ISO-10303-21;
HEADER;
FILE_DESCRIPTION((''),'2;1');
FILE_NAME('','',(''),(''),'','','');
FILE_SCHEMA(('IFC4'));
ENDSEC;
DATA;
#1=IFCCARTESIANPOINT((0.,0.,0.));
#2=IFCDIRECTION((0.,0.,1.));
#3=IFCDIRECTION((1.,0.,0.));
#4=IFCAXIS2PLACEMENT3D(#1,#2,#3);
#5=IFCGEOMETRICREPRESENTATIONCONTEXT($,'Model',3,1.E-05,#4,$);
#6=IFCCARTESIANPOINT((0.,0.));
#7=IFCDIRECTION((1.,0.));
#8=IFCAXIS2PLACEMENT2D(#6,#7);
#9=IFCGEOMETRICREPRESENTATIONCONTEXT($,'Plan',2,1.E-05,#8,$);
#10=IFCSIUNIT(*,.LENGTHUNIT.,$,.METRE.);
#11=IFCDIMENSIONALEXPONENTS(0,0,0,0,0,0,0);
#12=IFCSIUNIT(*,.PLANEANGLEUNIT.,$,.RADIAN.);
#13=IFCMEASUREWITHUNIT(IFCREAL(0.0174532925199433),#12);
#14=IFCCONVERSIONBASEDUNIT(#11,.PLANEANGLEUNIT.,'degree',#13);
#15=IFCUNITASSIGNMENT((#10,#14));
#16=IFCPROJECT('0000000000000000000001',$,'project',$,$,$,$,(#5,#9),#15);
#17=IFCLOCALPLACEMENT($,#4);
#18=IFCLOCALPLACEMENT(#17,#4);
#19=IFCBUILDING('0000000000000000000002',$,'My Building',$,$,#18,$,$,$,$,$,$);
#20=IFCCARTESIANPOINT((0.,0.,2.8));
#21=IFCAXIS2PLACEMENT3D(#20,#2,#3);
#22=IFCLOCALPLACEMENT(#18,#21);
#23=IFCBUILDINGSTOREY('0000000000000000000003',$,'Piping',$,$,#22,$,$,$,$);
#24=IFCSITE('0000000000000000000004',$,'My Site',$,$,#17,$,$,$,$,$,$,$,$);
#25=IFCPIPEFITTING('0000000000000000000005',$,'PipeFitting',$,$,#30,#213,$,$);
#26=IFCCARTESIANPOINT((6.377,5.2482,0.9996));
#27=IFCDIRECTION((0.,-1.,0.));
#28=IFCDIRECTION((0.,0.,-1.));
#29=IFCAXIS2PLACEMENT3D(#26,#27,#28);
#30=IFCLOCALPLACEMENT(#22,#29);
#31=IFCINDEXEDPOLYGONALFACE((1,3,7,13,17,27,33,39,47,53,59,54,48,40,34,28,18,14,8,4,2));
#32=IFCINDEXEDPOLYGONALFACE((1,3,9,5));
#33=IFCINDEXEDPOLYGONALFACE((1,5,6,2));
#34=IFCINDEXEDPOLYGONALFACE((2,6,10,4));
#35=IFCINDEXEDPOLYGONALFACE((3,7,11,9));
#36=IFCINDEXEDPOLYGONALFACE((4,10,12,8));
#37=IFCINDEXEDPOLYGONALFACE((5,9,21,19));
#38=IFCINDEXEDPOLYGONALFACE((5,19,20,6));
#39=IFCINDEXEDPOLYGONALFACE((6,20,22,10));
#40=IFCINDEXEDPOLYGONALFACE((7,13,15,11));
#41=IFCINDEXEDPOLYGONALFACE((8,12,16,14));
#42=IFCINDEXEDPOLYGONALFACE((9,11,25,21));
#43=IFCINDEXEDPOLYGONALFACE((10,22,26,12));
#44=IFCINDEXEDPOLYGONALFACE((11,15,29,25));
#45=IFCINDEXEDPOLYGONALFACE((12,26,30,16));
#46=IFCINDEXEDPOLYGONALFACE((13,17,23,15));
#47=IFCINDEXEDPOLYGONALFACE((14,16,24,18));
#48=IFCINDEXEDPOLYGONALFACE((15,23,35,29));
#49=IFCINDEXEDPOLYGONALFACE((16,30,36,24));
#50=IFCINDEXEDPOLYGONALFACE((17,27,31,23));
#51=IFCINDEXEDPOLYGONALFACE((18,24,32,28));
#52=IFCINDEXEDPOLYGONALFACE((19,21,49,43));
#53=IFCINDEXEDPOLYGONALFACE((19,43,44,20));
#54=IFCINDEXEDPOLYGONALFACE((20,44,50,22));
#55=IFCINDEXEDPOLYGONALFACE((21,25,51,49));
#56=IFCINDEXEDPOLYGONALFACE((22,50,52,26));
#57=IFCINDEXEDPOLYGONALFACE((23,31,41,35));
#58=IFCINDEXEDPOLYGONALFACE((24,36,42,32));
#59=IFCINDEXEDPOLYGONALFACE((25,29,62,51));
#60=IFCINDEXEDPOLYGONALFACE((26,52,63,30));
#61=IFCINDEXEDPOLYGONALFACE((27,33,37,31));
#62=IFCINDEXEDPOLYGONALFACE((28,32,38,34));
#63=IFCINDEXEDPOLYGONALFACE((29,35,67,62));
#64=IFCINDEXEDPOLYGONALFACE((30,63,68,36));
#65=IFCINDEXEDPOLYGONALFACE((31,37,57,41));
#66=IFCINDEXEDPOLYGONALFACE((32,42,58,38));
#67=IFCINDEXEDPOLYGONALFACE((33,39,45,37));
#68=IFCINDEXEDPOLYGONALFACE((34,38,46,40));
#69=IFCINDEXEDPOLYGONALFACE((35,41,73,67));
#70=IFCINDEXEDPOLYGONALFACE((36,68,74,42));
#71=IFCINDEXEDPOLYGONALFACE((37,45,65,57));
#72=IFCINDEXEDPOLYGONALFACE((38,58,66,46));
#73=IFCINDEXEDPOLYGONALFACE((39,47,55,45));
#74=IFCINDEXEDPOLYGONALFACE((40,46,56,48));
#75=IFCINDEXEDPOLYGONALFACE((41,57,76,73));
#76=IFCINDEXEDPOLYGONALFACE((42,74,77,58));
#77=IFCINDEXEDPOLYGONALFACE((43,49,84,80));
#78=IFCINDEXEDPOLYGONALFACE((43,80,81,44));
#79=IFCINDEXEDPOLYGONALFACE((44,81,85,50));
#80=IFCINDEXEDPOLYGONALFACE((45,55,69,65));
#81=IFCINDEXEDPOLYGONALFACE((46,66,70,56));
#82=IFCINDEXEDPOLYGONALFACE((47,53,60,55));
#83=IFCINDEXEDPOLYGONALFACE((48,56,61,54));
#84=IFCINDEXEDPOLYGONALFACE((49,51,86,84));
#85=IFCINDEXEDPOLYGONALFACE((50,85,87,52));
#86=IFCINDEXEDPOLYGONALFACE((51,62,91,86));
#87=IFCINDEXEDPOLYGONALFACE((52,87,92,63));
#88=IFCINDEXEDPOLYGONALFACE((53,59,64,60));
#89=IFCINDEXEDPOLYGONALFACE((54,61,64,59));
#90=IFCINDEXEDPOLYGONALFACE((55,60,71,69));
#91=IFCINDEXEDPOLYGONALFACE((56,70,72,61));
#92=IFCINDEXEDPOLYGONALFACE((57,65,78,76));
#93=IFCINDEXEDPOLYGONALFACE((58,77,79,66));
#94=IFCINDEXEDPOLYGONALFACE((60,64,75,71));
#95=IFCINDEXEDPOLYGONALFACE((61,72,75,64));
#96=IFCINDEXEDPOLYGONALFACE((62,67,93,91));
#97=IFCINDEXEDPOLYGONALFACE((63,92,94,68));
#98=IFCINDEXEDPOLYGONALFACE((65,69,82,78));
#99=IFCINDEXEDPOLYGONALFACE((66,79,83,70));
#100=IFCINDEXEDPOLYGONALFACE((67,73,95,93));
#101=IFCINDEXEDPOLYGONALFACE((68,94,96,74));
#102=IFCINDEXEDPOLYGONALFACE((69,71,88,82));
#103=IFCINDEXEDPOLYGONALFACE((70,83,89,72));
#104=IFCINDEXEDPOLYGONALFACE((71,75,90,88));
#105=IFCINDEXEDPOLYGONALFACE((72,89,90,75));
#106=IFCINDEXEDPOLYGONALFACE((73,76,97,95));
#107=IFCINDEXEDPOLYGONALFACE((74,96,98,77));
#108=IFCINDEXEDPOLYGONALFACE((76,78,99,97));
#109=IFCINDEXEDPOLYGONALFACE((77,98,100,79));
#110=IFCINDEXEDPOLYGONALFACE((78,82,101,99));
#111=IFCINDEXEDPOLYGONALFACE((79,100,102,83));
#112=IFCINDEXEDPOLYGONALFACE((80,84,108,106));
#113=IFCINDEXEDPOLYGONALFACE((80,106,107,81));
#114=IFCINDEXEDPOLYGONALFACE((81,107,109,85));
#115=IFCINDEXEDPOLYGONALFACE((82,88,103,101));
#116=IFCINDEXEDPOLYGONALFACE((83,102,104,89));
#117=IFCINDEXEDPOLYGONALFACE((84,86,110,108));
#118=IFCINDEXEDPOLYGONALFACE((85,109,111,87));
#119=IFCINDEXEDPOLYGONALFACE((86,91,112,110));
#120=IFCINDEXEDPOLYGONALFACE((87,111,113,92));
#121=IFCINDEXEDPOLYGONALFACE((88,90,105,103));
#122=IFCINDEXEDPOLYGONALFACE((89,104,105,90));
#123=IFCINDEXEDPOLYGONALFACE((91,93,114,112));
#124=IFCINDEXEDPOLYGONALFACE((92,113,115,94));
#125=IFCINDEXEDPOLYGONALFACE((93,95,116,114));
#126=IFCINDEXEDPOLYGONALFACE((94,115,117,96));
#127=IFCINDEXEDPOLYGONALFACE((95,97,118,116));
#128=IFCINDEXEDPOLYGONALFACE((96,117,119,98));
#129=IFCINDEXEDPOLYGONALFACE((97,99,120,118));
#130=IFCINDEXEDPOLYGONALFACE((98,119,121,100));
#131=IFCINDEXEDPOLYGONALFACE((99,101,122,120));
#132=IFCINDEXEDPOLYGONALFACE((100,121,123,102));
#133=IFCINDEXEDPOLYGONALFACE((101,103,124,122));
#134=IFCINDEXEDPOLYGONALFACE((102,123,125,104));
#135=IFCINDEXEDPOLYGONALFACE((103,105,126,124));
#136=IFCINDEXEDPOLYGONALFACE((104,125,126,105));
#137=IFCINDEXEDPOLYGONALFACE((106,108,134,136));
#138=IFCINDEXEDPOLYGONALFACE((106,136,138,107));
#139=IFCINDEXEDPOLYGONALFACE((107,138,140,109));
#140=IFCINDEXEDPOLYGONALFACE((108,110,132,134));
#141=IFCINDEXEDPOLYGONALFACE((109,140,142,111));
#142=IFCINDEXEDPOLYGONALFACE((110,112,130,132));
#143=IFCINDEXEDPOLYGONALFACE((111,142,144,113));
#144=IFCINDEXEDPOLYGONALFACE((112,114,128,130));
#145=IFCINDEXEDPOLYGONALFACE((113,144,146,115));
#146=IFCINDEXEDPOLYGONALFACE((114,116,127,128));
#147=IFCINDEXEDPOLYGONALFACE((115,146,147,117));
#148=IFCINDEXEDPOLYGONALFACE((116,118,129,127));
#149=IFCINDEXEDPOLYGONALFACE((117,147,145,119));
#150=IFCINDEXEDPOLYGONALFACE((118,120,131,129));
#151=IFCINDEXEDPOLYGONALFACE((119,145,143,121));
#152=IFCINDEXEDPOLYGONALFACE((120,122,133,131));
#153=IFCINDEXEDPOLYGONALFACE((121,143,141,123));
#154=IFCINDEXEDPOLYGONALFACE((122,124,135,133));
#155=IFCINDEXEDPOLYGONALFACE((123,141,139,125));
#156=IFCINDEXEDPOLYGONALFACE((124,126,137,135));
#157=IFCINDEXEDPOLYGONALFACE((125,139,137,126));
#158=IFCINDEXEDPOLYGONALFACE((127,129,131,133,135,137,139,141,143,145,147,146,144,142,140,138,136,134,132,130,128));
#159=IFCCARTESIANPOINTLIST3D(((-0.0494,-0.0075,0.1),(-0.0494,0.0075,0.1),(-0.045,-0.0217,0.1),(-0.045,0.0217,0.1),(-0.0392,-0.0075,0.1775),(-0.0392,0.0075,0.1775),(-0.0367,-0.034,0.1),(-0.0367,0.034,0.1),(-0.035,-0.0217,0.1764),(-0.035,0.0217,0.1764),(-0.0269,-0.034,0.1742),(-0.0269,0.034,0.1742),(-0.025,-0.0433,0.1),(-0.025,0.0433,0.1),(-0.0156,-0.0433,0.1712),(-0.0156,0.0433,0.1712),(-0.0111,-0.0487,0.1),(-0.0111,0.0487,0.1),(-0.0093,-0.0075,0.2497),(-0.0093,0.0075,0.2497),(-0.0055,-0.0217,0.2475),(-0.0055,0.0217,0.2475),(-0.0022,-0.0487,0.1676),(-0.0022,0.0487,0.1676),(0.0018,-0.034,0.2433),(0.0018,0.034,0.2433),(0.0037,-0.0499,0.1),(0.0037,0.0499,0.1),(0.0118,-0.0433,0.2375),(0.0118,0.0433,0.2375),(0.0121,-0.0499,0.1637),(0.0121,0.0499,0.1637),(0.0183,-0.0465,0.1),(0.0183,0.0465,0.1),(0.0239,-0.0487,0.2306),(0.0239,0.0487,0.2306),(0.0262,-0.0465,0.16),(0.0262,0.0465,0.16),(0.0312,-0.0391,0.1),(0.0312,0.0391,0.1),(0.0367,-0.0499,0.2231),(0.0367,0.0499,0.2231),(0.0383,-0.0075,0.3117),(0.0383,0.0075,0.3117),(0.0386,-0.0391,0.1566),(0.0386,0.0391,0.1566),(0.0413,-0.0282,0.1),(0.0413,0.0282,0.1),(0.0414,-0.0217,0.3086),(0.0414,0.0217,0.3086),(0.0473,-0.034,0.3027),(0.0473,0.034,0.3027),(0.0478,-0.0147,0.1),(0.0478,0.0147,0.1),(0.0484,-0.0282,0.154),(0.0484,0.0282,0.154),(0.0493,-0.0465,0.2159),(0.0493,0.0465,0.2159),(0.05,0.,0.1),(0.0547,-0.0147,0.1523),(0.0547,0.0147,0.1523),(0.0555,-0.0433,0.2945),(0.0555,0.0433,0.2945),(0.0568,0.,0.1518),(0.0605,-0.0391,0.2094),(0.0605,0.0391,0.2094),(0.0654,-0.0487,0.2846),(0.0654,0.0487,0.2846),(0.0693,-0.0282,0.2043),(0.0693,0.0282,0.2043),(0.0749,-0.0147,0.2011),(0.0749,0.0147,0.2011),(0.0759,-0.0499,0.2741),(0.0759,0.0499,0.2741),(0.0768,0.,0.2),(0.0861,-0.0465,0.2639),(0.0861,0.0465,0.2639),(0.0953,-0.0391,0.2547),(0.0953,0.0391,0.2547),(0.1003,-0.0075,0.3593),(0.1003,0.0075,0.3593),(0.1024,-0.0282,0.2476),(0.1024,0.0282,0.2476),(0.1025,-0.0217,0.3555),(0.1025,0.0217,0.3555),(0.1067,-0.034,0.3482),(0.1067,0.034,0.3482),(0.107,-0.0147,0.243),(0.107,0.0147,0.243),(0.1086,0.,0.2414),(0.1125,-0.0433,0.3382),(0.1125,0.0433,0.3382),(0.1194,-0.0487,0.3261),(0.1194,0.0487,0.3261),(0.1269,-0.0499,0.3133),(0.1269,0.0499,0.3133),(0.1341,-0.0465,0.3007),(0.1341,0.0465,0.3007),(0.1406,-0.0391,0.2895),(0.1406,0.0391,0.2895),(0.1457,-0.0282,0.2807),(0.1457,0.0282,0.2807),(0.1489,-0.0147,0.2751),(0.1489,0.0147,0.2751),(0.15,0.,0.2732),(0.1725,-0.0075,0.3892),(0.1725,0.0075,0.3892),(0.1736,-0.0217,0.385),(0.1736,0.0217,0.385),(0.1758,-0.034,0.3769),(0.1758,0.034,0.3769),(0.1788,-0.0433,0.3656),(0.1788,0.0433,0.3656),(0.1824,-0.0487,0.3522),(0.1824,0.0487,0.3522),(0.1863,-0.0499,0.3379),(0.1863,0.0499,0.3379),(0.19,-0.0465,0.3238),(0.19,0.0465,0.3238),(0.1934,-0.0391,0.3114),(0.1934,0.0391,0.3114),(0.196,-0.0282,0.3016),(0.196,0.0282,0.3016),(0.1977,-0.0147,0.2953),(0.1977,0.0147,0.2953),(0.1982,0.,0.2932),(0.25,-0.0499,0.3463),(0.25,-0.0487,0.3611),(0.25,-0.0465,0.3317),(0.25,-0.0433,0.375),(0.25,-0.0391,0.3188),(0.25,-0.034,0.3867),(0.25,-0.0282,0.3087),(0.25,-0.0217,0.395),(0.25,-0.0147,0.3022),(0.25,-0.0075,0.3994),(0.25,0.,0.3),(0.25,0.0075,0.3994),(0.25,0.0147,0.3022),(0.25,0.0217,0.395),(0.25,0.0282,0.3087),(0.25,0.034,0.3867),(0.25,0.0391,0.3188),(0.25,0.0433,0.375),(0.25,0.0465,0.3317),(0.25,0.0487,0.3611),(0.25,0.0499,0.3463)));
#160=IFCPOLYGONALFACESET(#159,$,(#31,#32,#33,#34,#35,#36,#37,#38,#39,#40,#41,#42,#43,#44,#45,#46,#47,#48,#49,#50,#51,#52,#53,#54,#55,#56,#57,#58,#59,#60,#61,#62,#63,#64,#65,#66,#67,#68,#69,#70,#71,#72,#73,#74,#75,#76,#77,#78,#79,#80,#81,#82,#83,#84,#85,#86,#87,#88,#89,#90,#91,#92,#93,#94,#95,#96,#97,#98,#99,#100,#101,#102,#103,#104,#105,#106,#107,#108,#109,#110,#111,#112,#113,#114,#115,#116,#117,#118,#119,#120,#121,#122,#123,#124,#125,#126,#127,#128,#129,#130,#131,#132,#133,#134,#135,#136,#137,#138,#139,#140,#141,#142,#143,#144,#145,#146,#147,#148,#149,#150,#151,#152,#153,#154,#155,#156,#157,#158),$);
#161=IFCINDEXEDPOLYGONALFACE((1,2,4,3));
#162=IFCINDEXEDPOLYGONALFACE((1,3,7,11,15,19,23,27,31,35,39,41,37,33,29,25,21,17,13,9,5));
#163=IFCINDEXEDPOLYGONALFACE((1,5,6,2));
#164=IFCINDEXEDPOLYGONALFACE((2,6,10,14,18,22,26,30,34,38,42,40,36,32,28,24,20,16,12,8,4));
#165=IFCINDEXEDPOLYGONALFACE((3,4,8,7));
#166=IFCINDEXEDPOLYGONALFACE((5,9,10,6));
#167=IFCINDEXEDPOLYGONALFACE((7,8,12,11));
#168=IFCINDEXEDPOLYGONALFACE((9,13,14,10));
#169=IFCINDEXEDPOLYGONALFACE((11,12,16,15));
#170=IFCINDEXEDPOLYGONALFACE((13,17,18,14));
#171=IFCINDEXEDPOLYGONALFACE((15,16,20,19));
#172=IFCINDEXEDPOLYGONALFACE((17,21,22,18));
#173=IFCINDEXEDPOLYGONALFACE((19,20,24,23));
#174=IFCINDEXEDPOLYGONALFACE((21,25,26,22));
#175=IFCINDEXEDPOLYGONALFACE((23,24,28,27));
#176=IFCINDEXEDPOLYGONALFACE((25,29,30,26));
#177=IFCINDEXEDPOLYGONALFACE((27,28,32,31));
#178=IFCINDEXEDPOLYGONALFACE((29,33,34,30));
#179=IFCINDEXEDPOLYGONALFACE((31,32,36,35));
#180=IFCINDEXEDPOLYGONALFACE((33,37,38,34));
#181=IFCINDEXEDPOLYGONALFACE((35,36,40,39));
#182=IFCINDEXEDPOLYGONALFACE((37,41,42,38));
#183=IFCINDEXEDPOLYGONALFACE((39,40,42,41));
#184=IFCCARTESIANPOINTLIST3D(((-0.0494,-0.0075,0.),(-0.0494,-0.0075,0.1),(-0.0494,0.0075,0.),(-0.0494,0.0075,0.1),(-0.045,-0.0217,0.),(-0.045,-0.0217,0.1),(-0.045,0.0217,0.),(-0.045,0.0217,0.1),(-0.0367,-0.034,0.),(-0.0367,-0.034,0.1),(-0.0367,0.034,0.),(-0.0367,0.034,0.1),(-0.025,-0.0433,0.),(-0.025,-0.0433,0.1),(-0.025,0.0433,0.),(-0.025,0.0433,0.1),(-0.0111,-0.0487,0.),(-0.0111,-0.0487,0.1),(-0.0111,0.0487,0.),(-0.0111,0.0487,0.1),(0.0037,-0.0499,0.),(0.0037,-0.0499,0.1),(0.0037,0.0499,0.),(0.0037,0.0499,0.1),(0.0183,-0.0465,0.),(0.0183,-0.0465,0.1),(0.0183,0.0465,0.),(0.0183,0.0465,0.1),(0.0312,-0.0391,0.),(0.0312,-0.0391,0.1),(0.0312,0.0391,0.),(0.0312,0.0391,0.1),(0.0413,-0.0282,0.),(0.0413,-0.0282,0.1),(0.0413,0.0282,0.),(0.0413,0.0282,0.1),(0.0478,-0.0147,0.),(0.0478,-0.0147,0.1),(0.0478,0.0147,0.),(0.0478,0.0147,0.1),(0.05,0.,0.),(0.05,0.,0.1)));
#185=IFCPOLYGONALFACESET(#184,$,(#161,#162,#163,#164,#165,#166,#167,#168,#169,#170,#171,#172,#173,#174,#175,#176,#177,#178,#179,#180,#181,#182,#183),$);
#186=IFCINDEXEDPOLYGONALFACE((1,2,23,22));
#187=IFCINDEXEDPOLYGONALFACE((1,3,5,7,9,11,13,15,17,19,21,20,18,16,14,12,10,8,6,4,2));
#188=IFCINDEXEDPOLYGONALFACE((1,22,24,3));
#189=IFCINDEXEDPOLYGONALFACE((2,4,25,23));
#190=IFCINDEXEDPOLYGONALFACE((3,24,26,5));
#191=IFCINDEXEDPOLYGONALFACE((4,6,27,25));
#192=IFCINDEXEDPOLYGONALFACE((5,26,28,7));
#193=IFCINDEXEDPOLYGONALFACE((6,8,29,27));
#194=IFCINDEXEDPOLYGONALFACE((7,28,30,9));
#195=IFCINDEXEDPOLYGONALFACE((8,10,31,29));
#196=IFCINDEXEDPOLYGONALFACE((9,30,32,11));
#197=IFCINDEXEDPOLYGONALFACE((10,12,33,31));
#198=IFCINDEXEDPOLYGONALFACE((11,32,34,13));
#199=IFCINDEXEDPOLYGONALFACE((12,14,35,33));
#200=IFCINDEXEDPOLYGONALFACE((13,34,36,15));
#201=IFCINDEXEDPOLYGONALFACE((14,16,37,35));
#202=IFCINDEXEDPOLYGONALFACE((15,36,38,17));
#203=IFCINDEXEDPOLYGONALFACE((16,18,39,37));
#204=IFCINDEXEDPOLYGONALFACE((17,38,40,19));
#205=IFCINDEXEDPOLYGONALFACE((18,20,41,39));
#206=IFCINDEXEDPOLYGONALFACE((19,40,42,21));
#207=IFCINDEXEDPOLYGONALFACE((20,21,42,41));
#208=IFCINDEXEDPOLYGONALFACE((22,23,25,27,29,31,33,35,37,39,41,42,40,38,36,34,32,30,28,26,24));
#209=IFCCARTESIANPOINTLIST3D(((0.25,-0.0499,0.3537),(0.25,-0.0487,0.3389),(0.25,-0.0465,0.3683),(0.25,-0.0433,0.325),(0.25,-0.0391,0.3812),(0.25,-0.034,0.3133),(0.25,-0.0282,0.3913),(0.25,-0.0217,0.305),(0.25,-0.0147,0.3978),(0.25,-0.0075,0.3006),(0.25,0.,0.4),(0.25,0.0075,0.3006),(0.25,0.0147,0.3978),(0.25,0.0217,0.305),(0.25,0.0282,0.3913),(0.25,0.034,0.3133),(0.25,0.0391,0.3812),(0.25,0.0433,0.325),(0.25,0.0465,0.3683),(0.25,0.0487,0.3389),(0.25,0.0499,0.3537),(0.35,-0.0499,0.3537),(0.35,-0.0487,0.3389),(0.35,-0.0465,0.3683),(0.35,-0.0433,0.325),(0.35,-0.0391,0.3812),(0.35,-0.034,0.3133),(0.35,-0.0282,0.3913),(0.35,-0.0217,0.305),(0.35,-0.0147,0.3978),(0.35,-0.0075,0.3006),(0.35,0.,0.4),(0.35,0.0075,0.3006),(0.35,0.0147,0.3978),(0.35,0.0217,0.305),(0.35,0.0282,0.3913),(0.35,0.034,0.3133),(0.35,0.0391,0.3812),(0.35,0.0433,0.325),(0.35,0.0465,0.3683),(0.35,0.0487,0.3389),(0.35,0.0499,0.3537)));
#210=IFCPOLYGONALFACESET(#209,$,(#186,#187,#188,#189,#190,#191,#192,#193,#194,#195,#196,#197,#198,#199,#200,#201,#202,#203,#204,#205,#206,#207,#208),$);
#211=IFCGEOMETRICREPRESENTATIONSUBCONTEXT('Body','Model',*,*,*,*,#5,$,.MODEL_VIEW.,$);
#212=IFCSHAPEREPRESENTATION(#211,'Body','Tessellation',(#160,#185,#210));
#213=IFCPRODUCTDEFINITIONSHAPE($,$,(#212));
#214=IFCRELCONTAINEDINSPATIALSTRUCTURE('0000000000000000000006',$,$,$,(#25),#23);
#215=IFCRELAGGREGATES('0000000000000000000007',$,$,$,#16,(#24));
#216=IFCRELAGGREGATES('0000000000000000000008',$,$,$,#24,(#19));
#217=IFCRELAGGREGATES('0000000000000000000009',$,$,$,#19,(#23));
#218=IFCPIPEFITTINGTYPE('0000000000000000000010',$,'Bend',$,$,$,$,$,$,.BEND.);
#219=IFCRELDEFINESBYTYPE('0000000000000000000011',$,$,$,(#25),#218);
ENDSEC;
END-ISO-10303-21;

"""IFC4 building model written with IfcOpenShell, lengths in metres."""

from ifc_helpers import new_model, entity, si_unit, converted_unit, frame, origin_with_axes, origin_2d_with_axis, place, context, subcontext, project, spatial, circle, extrude, source, transform, mapped, type_object, type_shapes, element, save


model = new_model("IFC4")

# Units and contexts
model_context = context("Model", 3, precision=1e-05, world=origin_with_axes())
plan_context = context("Plan", 2, precision=1e-05, world=origin_2d_with_axis())
body_context = subcontext(model_context, "Body", "Model", "MODEL_VIEW")
ifc_project = project(units=[si_unit("LENGTHUNIT", "METRE"), converted_unit("PLANEANGLEUNIT", "degree", entity("IfcReal", 0.0174532925199433), si_unit("PLANEANGLEUNIT", "RADIAN"), dimensions=[0, 0, 0, 0, 0, 0, 0])], contexts=[model_context, plan_context])

# Site, building, storey
site_placement = place(None, origin_with_axes())
site = spatial("IfcSite", under=ifc_project, at=site_placement, Name="My Site")
building_placement = place(site_placement, origin_with_axes())
building = spatial("IfcBuilding", under=site, at=building_placement, Name="My Building")
storey_placement = place(building_placement, frame((0.0, 0.0, 2.8), z_axis=(0.0, 0.0, 1.0), x_axis=(1.0, 0.0, 0.0)))
storey = spatial("IfcBuildingStorey", under=building, at=storey_placement, Name="Piping")

# Pipe fitting
pipe_fitting_type_1 = type_object("IfcPipeFittingType", Name="Bend", PredefinedType="BEND")
shared_shape = source(origin_with_axes(), body_context, "Body", "SolidModel", [
    entity("IfcSweptDiskSolid", entity("IfcIndexedPolyCurve", entity("IfcCartesianPointList3D", [[0.0, 0.0, 0.1], [0.0732, 0.0, 0.2768], [0.25, 0.0, 0.35]]), [entity("IfcArcIndex", [1, 2, 3])]), 0.05),
    extrude(circle(Radius=0.05), origin_with_axes(), (0.0, 0.0, 1.0), 0.1),
    extrude(circle(Radius=0.05), frame((0.25, 0.0, 0.35), z_axis=(1.0, 0.0, 0.0), x_axis=(0.0, 0.0, 1.0)), (0.0, 0.0, 1.0), 0.1),
])
type_shapes(pipe_fitting_type_1, [shared_shape])
for number, where, z_axis, x_axis, name in (
    (1, (6.377, 5.2482, 0.9996), (0.0, -1.0, 0.0), (0.0, 0.0, -1.0), "PipeFitting"),
):
    element("IfcPipeFitting", number, at=place(storey_placement, frame(where, z_axis=z_axis, x_axis=x_axis)), inside=storey, type_object=pipe_fitting_type_1, Name=name, context=body_context, shape_type="MappedRepresentation", body=[
        mapped(shared_shape, transform((0.0, 0.0, 0.0), x_axis=(1.0, 0.0, 0.0), y_axis=(0.0, 1.0, 0.0), z_axis=(0.0, 0.0, 1.0), scale=1.0)),
    ])

save(model, "model.ifc")
